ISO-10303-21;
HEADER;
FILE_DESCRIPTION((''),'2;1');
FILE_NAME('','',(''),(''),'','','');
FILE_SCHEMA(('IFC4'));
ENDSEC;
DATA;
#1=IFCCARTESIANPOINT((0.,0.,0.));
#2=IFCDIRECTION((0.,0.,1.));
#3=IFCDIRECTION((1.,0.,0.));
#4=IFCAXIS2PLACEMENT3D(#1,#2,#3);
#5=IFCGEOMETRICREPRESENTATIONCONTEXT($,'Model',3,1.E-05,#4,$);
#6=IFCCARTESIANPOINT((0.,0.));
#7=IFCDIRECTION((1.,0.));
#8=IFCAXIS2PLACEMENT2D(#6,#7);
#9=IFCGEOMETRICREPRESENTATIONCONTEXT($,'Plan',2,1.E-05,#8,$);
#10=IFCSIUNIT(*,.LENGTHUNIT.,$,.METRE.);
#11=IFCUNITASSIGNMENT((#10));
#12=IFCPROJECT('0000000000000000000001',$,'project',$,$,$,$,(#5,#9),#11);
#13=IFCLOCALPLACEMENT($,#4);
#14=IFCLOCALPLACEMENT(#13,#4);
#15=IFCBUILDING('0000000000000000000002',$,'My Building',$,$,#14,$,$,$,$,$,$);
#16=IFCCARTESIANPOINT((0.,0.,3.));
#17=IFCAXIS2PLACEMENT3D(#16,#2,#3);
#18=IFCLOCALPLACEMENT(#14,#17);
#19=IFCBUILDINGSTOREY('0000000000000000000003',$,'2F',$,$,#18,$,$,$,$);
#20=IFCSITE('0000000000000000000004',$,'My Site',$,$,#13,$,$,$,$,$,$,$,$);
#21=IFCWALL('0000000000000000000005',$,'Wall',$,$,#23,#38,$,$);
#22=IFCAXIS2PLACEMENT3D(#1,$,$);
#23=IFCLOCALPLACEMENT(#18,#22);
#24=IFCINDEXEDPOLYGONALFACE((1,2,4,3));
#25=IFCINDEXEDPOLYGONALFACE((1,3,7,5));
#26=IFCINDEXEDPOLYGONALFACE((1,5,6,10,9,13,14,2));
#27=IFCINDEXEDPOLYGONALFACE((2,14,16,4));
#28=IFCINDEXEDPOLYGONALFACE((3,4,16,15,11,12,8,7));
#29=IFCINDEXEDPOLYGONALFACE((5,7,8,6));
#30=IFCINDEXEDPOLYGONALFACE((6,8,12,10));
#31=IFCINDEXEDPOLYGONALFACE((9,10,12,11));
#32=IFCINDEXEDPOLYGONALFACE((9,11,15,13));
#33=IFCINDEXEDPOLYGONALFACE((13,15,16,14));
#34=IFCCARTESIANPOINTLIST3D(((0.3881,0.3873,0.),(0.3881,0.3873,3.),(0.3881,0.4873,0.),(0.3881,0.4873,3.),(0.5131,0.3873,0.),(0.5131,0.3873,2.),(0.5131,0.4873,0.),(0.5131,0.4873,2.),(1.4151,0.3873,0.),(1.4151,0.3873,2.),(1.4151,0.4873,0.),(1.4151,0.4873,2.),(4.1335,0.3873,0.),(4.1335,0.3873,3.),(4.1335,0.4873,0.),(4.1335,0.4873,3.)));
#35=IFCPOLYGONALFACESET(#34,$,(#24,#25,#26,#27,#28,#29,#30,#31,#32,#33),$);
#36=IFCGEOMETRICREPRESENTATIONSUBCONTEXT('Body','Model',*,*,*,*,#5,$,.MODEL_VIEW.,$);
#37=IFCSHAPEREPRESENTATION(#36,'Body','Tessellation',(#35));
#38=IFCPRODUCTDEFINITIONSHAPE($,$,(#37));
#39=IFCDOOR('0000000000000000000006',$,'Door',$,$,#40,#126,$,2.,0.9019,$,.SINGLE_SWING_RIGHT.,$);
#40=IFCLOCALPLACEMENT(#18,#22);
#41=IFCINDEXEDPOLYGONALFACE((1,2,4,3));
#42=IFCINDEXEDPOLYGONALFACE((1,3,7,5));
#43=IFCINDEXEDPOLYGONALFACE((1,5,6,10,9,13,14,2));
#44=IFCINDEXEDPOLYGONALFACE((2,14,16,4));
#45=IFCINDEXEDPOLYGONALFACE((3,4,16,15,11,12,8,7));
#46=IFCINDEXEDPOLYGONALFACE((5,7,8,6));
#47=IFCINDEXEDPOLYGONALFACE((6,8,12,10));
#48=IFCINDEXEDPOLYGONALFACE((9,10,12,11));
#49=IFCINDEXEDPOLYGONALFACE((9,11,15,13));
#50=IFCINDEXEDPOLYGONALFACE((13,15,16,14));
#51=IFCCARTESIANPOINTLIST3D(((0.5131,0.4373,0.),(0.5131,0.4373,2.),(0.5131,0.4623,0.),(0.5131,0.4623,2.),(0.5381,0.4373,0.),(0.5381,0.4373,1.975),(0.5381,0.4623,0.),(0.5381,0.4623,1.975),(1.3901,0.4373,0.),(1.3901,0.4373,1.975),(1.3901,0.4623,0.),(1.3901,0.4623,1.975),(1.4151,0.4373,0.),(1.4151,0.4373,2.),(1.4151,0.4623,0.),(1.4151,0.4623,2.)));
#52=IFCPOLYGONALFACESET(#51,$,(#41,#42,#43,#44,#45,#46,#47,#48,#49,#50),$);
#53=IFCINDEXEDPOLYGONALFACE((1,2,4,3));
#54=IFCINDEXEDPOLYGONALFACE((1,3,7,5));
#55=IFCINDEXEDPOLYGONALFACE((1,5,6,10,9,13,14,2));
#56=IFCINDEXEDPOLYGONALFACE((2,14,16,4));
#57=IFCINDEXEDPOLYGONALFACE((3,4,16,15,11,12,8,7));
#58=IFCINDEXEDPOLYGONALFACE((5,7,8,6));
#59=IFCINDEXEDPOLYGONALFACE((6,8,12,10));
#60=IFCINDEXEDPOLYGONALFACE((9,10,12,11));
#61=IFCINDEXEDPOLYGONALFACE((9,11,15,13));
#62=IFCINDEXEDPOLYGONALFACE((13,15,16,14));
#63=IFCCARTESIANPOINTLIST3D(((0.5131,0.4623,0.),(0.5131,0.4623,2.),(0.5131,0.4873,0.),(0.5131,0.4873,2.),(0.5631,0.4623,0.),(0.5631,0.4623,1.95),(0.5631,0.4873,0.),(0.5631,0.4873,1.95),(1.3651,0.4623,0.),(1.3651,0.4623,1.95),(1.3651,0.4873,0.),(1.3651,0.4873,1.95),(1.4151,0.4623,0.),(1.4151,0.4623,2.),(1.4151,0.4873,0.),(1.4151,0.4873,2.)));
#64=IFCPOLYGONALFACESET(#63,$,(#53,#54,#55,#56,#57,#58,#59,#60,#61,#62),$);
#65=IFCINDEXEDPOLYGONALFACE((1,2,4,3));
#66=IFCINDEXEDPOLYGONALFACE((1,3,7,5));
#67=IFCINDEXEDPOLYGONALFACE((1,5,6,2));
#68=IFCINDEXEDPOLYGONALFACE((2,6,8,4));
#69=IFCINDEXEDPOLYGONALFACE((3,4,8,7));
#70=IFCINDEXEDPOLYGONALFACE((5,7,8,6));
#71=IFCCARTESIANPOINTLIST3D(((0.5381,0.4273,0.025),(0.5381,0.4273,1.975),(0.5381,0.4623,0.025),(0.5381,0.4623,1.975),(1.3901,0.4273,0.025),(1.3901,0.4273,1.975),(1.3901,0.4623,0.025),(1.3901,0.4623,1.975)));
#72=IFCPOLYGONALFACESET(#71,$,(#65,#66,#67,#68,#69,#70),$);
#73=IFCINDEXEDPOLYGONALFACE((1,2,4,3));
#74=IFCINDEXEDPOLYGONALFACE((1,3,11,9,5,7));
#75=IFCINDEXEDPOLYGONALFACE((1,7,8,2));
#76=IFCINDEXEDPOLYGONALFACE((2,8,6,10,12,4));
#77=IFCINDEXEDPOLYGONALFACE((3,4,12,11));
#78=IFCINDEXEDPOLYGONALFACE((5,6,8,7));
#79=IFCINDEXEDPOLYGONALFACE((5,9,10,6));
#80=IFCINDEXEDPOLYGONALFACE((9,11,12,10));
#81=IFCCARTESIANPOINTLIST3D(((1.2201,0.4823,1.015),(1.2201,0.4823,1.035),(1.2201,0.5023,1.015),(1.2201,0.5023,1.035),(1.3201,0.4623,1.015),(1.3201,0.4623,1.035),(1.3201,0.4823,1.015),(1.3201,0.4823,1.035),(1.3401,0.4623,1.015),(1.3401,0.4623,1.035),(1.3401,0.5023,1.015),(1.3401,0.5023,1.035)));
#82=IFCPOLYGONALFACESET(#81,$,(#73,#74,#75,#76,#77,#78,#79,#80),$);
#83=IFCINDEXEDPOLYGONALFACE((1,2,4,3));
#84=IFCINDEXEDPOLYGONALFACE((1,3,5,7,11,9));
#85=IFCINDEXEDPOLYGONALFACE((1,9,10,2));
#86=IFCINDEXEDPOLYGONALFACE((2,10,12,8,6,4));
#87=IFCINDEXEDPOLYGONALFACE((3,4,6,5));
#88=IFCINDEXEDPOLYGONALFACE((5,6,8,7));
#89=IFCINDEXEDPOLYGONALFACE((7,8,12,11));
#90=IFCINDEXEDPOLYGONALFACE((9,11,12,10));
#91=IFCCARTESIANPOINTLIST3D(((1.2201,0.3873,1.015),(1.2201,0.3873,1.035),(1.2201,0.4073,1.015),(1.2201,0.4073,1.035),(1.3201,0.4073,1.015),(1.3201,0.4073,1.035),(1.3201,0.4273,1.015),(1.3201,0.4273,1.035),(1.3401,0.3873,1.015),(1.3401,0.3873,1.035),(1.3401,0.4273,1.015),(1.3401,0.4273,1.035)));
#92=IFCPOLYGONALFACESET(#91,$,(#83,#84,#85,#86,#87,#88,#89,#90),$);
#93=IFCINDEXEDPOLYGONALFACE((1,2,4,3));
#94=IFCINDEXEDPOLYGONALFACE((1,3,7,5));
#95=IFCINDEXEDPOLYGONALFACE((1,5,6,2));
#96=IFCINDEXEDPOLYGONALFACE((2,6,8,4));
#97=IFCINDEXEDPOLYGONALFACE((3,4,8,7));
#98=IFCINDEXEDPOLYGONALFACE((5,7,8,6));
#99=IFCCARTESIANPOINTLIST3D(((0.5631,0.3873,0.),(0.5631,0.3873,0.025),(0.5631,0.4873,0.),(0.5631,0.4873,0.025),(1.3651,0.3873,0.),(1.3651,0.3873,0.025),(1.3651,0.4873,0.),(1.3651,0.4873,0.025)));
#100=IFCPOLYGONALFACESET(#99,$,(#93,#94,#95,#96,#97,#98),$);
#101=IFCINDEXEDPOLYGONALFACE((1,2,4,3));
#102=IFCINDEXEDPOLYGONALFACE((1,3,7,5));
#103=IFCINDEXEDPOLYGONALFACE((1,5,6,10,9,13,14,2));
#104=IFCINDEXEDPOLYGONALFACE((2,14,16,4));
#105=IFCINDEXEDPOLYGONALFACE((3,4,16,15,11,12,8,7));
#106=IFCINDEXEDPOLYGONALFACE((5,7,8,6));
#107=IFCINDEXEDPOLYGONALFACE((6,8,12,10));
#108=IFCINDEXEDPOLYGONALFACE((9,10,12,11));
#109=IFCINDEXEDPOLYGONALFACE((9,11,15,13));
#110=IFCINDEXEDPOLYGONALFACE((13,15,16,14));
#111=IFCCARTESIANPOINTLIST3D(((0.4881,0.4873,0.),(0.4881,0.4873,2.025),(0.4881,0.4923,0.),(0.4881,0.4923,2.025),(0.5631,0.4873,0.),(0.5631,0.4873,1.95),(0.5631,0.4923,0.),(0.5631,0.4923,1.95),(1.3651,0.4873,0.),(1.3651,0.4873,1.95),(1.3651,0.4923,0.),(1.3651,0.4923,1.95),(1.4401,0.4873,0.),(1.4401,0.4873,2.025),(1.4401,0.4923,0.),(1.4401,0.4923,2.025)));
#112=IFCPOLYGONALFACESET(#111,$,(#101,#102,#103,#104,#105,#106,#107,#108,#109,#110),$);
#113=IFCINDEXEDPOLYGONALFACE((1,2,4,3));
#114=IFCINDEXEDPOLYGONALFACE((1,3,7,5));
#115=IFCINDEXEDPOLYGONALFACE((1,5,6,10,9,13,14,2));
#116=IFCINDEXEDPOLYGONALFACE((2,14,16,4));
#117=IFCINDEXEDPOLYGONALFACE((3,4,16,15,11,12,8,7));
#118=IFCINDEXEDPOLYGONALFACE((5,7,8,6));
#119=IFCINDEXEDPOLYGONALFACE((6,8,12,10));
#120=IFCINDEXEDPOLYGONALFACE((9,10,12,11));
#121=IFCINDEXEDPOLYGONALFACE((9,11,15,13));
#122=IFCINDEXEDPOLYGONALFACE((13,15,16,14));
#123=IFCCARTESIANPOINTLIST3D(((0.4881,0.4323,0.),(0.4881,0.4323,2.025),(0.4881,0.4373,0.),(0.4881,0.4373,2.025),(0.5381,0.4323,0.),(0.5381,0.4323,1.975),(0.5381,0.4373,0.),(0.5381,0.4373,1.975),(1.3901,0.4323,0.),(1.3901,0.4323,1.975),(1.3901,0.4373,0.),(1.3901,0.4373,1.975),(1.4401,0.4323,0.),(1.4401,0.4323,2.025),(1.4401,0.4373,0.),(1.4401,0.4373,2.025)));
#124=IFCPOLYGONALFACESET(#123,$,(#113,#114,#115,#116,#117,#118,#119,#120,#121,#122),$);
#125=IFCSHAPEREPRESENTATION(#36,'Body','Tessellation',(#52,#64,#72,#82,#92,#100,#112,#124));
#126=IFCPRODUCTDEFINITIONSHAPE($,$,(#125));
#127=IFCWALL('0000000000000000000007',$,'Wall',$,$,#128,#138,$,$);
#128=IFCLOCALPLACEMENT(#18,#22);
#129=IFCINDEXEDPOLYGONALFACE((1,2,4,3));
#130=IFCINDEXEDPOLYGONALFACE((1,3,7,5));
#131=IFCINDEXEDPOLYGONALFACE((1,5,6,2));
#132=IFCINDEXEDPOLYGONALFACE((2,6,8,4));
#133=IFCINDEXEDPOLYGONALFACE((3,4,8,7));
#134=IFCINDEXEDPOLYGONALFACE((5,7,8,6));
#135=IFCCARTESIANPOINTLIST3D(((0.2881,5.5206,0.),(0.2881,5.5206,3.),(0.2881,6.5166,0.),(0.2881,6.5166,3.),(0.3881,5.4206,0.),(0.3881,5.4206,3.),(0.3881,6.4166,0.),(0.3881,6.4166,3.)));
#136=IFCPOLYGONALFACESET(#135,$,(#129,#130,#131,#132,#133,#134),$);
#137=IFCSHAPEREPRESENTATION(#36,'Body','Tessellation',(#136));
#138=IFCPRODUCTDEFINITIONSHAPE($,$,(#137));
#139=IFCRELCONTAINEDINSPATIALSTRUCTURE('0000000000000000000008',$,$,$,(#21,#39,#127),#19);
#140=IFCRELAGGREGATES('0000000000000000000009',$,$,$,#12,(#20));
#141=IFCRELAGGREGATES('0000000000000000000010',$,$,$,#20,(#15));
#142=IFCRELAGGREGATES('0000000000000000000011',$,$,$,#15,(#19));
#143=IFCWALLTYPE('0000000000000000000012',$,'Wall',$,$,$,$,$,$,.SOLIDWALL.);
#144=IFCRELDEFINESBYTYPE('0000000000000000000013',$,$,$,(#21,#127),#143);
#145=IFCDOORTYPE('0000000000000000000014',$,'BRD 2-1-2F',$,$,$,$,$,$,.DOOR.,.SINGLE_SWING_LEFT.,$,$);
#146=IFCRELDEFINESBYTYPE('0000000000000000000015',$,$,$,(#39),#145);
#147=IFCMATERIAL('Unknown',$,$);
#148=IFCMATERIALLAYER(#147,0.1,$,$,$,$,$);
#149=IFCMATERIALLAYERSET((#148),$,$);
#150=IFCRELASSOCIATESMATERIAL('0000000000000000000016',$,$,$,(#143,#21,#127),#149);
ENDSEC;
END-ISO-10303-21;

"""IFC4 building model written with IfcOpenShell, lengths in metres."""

from ifc_helpers import new_model, entity, si_unit, frame, origin_with_axes, origin_2d_with_axis, place, context, subcontext, project, spatial, line, indexed_curve, outline, extrude, shape, source, transform, mapped, material, layer, layer_set, layer_usage, type_object, type_shapes, element, fill, save


model = new_model("IFC4")

# Units and contexts
model_context = context("Model", 3, precision=1e-05, world=origin_with_axes())
plan_context = context("Plan", 2, precision=1e-05, world=origin_2d_with_axis())
body_context_1 = subcontext(model_context, "Body", "Model", "MODEL_VIEW")
body_context_2 = subcontext(plan_context, "Body", "Plan", "PLAN_VIEW")
ifc_project = project(units=[si_unit("LENGTHUNIT", "METRE")], contexts=[model_context, plan_context])

# Site, building, storey
site_placement = place(None, origin_with_axes())
site = spatial("IfcSite", under=ifc_project, at=site_placement, Name="My Site")
building_placement = place(site_placement, origin_with_axes())
building = spatial("IfcBuilding", under=site, at=building_placement, Name="My Building")
storey_placement = place(building_placement, frame((0.0, 0.0, 3.0), z_axis=(0.0, 0.0, 1.0), x_axis=(1.0, 0.0, 0.0)))
storey = spatial("IfcBuildingStorey", under=building, at=storey_placement, Name="2F")

# Shared definitions
ifc_material = material(Name="Unknown")

# Shared definitions
ifc_layer_1 = layer(ifc_material, 0.1)
ifc_layer_set_1 = layer_set([ifc_layer_1])
wall_type = type_object("IfcWallType", Name="Wall", PredefinedType="SOLIDWALL", material=ifc_layer_set_1)

# Wall, opening, door
ifc_layer_usage_1 = layer_usage(ifc_layer_set_1, "AXIS2", "POSITIVE", 0.0)
wall_1_placement = place(storey_placement, frame((0.3881, 0.3873, 0.0), z_axis=(0.0, 0.0, 1.0), x_axis=(1.0, 0.0, 0.0)))
wall_1 = element("IfcWall", 1, at=wall_1_placement, inside=storey, type_object=wall_type, material=ifc_layer_usage_1, Name="Wall", context=body_context_1, shape_type="SweptSolid", body=[
    extrude(outline(indexed_curve([(0.0, 0.0), (0.0, 0.1), (3.7454, 0.1), (3.7454, 0.0)], segments=[line(1, 2, 3, 4, 1)])), origin_with_axes(), (0.0, 0.0, 1.0), 3.0),
])
shared_shape_1 = source(origin_with_axes(), body_context_1, "Body", "SweptSolid", [
    extrude(outline(indexed_curve([(0.0, 0.0), (0.9019, 0.0), (0.9019, 2.0), (0.0, 2.0)], segments=[line(1, 2, 3, 4, 1)])), frame((0.0, -0.6, 0.0), z_axis=(0.0, -1.0, 0.0), x_axis=(1.0, 0.0, 0.0)), (0.0, 0.0, -1.0), 1.2),
])
opening_1_placement = place(wall_1_placement, frame((1.0269, 0.1, 0.0), z_axis=(0.0, 0.0, 1.0), x_axis=(-1.0, 0.000001, 0.0)))
opening_1 = element("IfcOpeningElement", 2, at=opening_1_placement, cuts=wall_1, PredefinedType="OPENING", context=body_context_1, shape_type="MappedRepresentation", body=[
    mapped(shared_shape_1, transform((0.0, 0.0, 0.0), x_axis=(1.0, 0.0, 0.0), y_axis=(0.0, 1.0, 0.0), z_axis=(0.0, 0.0, 1.0), scale=1.0)),
])
door_type_1 = type_object("IfcDoorType", Name="BRD 2-1-2F", OperationType="SINGLE_SWING_LEFT", PredefinedType="DOOR")
shared_shape_2 = source(origin_with_axes(), body_context_1, "Body", "SweptSolid", [
    extrude(outline(indexed_curve([(0.0, 0.0), (0.0, 2.0), (0.9019, 2.0), (0.9019, 0.0), (0.8769, 0.0), (0.8769, 1.975), (0.025, 1.975), (0.025, 0.0)], segments=[line(1, 2, 3, 4, 5, 6, 7, 8, 1)])), frame((0.0, 0.025, 0.0), z_axis=(0.0, -1.0, 0.0), x_axis=(1.0, 0.0, 0.0)), (0.0, 0.0, -1.0), 0.025),
    extrude(outline(indexed_curve([(0.0, 0.0), (0.0, 2.0), (0.9019, 2.0), (0.9019, 0.0), (0.8519, 0.0), (0.8519, 1.95), (0.05, 1.95), (0.05, 0.0)], segments=[line(1, 2, 3, 4, 5, 6, 7, 8, 1)])), frame((0.0, 0.0, 0.0), z_axis=(0.0, -1.0, 0.0), x_axis=(1.0, 0.0, 0.0)), (0.0, 0.0, -1.0), 0.025),
    extrude(outline(indexed_curve([(0.0, 0.0), (0.8519, 0.0), (0.8519, 0.035), (0.0, 0.035)], segments=[line(1, 2, 3, 4, 1)])), frame((0.025, 0.025, 0.025), z_axis=(0.0, 0.0, 1.0), x_axis=(1.0, 0.0, 0.0)), (0.0, 0.0, 1.0), 1.95),
    extrude(outline(indexed_curve([(0.0, 0.0), (0.0, -0.04), (0.12, -0.04), (0.12, -0.02), (0.02, -0.02), (0.02, 0.0)], segments=[line(1, 2, 3, 4, 5, 6, 1)])), frame((0.075, 0.025, 1.015), z_axis=(0.0, 0.0, 1.0), x_axis=(1.0, 0.0, 0.0)), (0.0, 0.0, 1.0), 0.02),
    extrude(outline(indexed_curve([(0.0, 0.0), (0.0, 0.04), (0.12, 0.04), (0.12, 0.02), (0.02, 0.02), (0.02, 0.0)], segments=[line(1, 2, 3, 4, 5, 6, 1)])), frame((0.075, 0.06, 1.015), z_axis=(0.0, 0.0, 1.0), x_axis=(1.0, 0.0, 0.0)), (0.0, 0.0, 1.0), 0.02),
    extrude(outline(indexed_curve([(0.0, 0.0), (0.8019, 0.0), (0.8019, 0.1), (0.0, 0.1)], segments=[line(1, 2, 3, 4, 1)])), frame((0.05, 0.0, 0.0), z_axis=(0.0, 0.0, 1.0), x_axis=(1.0, 0.0, 0.0)), (0.0, 0.0, 1.0), 0.025),
    extrude(outline(indexed_curve([(0.0, 0.0), (0.0, 2.025), (0.9519, 2.025), (0.9519, 0.0), (0.8769, 0.0), (0.8769, 1.95), (0.075, 1.95), (0.075, 0.0)], segments=[line(1, 2, 3, 4, 5, 6, 7, 8, 1)])), frame((-0.025, -0.005, 0.0), z_axis=(0.0, -1.0, 0.0), x_axis=(1.0, 0.0, 0.0)), (0.0, 0.0, -1.0), 0.005),
    extrude(outline(indexed_curve([(0.0, 0.0), (0.0, 2.025), (0.9519, 2.025), (0.9519, 0.0), (0.9019, 0.0), (0.9019, 1.975), (0.05, 1.975), (0.05, 0.0)], segments=[line(1, 2, 3, 4, 5, 6, 7, 8, 1)])), frame((-0.025, 0.05, 0.0), z_axis=(0.0, -1.0, 0.0), x_axis=(1.0, 0.0, 0.0)), (0.0, 0.0, -1.0), 0.005),
])
shared_shape_3 = source(origin_with_axes(), body_context_2, "Body", "Curve2D", [
    entity("IfcIndexedPolyCurve", entity("IfcCartesianPointList2D", [[0.0, 0.0], [0.0, 0.05], [0.025, 0.05], [0.025, 0.025], [0.05, 0.025], [0.05, 0.0]]), [entity("IfcLineIndex", [1, 2, 3, 4, 5, 6, 1])]),
    entity("IfcIndexedPolyCurve", entity("IfcCartesianPointList2D", [[0.9019, 0.0], [0.9019, 0.05], [0.8769, 0.05], [0.8769, 0.025], [0.8519, 0.025], [0.8519, 0.0]]), [entity("IfcLineIndex", [1, 2, 3, 4, 5, 6, 1])]),
    entity("IfcTrimmedCurve", entity("IfcEllipse", entity("IfcAxis2Placement2D", entity("IfcCartesianPoint", [0.8419, 0.05]), entity("IfcDirection", [1.0, 0.0])), 0.8169, 0.8519), [entity("IfcCartesianPoint", [0.8419, 0.9019])], [entity("IfcCartesianPoint", [0.025, 0.05])], True, "CARTESIAN"),
    entity("IfcIndexedPolyCurve", entity("IfcCartesianPointList2D", [[0.8769, 0.05], [0.8419, 0.05], [0.8419, 0.9019], [0.8769, 0.9019]]), [entity("IfcLineIndex", [1, 2, 3, 4, 1])]),
])
type_shapes(door_type_1, [shared_shape_2, shared_shape_3])
door_1_placement = place(opening_1_placement, frame((0.0, 0.0, 0.0), z_axis=(0.0, 0.0, 1.0), x_axis=(1.0, 0.0, 0.0)))
door_1 = element("IfcDoor", 3, at=door_1_placement, inside=storey, type_object=door_type_1, Name="Door", OperationType="SINGLE_SWING_RIGHT", OverallHeight=2.0, OverallWidth=0.9019, shapes=[
    shape(body_context_1, "Body", "MappedRepresentation", [mapped(shared_shape_2, transform((0.0, 0.0, 0.0), x_axis=(1.0, 0.0, 0.0), y_axis=(0.0, 1.0, 0.0), z_axis=(0.0, 0.0, 1.0), scale=1.0))]),
    shape(body_context_2, "Body", "MappedRepresentation", [mapped(shared_shape_3, transform((0.0, 0.0, 0.0), x_axis=(1.0, 0.0, 0.0), y_axis=(0.0, 1.0, 0.0), z_axis=(0.0, 0.0, 1.0), scale=1.0))]),
])
fill(opening_1, door_1)

# Wall
ifc_layer_usage_2 = layer_usage(ifc_layer_set_1, "AXIS2", "POSITIVE", 0.0)
wall_2_placement = place(storey_placement, frame((0.3881, 5.5206, 0.0), z_axis=(0.0, 0.0, 1.0), x_axis=(0.0, 1.0, 0.0)))
element("IfcWall", 4, at=wall_2_placement, inside=storey, type_object=wall_type, material=ifc_layer_usage_2, Name="Wall", context=body_context_1, shape_type="SweptSolid", body=[
    extrude(outline(indexed_curve([(-0.1, 0.0), (0.0, 0.1), (0.9959, 0.1), (0.8959, 0.0)], segments=[line(1, 2, 3, 4, 1)])), origin_with_axes(), (0.0, 0.0, 1.0), 3.0),
])

save(model, "model.ifc")
